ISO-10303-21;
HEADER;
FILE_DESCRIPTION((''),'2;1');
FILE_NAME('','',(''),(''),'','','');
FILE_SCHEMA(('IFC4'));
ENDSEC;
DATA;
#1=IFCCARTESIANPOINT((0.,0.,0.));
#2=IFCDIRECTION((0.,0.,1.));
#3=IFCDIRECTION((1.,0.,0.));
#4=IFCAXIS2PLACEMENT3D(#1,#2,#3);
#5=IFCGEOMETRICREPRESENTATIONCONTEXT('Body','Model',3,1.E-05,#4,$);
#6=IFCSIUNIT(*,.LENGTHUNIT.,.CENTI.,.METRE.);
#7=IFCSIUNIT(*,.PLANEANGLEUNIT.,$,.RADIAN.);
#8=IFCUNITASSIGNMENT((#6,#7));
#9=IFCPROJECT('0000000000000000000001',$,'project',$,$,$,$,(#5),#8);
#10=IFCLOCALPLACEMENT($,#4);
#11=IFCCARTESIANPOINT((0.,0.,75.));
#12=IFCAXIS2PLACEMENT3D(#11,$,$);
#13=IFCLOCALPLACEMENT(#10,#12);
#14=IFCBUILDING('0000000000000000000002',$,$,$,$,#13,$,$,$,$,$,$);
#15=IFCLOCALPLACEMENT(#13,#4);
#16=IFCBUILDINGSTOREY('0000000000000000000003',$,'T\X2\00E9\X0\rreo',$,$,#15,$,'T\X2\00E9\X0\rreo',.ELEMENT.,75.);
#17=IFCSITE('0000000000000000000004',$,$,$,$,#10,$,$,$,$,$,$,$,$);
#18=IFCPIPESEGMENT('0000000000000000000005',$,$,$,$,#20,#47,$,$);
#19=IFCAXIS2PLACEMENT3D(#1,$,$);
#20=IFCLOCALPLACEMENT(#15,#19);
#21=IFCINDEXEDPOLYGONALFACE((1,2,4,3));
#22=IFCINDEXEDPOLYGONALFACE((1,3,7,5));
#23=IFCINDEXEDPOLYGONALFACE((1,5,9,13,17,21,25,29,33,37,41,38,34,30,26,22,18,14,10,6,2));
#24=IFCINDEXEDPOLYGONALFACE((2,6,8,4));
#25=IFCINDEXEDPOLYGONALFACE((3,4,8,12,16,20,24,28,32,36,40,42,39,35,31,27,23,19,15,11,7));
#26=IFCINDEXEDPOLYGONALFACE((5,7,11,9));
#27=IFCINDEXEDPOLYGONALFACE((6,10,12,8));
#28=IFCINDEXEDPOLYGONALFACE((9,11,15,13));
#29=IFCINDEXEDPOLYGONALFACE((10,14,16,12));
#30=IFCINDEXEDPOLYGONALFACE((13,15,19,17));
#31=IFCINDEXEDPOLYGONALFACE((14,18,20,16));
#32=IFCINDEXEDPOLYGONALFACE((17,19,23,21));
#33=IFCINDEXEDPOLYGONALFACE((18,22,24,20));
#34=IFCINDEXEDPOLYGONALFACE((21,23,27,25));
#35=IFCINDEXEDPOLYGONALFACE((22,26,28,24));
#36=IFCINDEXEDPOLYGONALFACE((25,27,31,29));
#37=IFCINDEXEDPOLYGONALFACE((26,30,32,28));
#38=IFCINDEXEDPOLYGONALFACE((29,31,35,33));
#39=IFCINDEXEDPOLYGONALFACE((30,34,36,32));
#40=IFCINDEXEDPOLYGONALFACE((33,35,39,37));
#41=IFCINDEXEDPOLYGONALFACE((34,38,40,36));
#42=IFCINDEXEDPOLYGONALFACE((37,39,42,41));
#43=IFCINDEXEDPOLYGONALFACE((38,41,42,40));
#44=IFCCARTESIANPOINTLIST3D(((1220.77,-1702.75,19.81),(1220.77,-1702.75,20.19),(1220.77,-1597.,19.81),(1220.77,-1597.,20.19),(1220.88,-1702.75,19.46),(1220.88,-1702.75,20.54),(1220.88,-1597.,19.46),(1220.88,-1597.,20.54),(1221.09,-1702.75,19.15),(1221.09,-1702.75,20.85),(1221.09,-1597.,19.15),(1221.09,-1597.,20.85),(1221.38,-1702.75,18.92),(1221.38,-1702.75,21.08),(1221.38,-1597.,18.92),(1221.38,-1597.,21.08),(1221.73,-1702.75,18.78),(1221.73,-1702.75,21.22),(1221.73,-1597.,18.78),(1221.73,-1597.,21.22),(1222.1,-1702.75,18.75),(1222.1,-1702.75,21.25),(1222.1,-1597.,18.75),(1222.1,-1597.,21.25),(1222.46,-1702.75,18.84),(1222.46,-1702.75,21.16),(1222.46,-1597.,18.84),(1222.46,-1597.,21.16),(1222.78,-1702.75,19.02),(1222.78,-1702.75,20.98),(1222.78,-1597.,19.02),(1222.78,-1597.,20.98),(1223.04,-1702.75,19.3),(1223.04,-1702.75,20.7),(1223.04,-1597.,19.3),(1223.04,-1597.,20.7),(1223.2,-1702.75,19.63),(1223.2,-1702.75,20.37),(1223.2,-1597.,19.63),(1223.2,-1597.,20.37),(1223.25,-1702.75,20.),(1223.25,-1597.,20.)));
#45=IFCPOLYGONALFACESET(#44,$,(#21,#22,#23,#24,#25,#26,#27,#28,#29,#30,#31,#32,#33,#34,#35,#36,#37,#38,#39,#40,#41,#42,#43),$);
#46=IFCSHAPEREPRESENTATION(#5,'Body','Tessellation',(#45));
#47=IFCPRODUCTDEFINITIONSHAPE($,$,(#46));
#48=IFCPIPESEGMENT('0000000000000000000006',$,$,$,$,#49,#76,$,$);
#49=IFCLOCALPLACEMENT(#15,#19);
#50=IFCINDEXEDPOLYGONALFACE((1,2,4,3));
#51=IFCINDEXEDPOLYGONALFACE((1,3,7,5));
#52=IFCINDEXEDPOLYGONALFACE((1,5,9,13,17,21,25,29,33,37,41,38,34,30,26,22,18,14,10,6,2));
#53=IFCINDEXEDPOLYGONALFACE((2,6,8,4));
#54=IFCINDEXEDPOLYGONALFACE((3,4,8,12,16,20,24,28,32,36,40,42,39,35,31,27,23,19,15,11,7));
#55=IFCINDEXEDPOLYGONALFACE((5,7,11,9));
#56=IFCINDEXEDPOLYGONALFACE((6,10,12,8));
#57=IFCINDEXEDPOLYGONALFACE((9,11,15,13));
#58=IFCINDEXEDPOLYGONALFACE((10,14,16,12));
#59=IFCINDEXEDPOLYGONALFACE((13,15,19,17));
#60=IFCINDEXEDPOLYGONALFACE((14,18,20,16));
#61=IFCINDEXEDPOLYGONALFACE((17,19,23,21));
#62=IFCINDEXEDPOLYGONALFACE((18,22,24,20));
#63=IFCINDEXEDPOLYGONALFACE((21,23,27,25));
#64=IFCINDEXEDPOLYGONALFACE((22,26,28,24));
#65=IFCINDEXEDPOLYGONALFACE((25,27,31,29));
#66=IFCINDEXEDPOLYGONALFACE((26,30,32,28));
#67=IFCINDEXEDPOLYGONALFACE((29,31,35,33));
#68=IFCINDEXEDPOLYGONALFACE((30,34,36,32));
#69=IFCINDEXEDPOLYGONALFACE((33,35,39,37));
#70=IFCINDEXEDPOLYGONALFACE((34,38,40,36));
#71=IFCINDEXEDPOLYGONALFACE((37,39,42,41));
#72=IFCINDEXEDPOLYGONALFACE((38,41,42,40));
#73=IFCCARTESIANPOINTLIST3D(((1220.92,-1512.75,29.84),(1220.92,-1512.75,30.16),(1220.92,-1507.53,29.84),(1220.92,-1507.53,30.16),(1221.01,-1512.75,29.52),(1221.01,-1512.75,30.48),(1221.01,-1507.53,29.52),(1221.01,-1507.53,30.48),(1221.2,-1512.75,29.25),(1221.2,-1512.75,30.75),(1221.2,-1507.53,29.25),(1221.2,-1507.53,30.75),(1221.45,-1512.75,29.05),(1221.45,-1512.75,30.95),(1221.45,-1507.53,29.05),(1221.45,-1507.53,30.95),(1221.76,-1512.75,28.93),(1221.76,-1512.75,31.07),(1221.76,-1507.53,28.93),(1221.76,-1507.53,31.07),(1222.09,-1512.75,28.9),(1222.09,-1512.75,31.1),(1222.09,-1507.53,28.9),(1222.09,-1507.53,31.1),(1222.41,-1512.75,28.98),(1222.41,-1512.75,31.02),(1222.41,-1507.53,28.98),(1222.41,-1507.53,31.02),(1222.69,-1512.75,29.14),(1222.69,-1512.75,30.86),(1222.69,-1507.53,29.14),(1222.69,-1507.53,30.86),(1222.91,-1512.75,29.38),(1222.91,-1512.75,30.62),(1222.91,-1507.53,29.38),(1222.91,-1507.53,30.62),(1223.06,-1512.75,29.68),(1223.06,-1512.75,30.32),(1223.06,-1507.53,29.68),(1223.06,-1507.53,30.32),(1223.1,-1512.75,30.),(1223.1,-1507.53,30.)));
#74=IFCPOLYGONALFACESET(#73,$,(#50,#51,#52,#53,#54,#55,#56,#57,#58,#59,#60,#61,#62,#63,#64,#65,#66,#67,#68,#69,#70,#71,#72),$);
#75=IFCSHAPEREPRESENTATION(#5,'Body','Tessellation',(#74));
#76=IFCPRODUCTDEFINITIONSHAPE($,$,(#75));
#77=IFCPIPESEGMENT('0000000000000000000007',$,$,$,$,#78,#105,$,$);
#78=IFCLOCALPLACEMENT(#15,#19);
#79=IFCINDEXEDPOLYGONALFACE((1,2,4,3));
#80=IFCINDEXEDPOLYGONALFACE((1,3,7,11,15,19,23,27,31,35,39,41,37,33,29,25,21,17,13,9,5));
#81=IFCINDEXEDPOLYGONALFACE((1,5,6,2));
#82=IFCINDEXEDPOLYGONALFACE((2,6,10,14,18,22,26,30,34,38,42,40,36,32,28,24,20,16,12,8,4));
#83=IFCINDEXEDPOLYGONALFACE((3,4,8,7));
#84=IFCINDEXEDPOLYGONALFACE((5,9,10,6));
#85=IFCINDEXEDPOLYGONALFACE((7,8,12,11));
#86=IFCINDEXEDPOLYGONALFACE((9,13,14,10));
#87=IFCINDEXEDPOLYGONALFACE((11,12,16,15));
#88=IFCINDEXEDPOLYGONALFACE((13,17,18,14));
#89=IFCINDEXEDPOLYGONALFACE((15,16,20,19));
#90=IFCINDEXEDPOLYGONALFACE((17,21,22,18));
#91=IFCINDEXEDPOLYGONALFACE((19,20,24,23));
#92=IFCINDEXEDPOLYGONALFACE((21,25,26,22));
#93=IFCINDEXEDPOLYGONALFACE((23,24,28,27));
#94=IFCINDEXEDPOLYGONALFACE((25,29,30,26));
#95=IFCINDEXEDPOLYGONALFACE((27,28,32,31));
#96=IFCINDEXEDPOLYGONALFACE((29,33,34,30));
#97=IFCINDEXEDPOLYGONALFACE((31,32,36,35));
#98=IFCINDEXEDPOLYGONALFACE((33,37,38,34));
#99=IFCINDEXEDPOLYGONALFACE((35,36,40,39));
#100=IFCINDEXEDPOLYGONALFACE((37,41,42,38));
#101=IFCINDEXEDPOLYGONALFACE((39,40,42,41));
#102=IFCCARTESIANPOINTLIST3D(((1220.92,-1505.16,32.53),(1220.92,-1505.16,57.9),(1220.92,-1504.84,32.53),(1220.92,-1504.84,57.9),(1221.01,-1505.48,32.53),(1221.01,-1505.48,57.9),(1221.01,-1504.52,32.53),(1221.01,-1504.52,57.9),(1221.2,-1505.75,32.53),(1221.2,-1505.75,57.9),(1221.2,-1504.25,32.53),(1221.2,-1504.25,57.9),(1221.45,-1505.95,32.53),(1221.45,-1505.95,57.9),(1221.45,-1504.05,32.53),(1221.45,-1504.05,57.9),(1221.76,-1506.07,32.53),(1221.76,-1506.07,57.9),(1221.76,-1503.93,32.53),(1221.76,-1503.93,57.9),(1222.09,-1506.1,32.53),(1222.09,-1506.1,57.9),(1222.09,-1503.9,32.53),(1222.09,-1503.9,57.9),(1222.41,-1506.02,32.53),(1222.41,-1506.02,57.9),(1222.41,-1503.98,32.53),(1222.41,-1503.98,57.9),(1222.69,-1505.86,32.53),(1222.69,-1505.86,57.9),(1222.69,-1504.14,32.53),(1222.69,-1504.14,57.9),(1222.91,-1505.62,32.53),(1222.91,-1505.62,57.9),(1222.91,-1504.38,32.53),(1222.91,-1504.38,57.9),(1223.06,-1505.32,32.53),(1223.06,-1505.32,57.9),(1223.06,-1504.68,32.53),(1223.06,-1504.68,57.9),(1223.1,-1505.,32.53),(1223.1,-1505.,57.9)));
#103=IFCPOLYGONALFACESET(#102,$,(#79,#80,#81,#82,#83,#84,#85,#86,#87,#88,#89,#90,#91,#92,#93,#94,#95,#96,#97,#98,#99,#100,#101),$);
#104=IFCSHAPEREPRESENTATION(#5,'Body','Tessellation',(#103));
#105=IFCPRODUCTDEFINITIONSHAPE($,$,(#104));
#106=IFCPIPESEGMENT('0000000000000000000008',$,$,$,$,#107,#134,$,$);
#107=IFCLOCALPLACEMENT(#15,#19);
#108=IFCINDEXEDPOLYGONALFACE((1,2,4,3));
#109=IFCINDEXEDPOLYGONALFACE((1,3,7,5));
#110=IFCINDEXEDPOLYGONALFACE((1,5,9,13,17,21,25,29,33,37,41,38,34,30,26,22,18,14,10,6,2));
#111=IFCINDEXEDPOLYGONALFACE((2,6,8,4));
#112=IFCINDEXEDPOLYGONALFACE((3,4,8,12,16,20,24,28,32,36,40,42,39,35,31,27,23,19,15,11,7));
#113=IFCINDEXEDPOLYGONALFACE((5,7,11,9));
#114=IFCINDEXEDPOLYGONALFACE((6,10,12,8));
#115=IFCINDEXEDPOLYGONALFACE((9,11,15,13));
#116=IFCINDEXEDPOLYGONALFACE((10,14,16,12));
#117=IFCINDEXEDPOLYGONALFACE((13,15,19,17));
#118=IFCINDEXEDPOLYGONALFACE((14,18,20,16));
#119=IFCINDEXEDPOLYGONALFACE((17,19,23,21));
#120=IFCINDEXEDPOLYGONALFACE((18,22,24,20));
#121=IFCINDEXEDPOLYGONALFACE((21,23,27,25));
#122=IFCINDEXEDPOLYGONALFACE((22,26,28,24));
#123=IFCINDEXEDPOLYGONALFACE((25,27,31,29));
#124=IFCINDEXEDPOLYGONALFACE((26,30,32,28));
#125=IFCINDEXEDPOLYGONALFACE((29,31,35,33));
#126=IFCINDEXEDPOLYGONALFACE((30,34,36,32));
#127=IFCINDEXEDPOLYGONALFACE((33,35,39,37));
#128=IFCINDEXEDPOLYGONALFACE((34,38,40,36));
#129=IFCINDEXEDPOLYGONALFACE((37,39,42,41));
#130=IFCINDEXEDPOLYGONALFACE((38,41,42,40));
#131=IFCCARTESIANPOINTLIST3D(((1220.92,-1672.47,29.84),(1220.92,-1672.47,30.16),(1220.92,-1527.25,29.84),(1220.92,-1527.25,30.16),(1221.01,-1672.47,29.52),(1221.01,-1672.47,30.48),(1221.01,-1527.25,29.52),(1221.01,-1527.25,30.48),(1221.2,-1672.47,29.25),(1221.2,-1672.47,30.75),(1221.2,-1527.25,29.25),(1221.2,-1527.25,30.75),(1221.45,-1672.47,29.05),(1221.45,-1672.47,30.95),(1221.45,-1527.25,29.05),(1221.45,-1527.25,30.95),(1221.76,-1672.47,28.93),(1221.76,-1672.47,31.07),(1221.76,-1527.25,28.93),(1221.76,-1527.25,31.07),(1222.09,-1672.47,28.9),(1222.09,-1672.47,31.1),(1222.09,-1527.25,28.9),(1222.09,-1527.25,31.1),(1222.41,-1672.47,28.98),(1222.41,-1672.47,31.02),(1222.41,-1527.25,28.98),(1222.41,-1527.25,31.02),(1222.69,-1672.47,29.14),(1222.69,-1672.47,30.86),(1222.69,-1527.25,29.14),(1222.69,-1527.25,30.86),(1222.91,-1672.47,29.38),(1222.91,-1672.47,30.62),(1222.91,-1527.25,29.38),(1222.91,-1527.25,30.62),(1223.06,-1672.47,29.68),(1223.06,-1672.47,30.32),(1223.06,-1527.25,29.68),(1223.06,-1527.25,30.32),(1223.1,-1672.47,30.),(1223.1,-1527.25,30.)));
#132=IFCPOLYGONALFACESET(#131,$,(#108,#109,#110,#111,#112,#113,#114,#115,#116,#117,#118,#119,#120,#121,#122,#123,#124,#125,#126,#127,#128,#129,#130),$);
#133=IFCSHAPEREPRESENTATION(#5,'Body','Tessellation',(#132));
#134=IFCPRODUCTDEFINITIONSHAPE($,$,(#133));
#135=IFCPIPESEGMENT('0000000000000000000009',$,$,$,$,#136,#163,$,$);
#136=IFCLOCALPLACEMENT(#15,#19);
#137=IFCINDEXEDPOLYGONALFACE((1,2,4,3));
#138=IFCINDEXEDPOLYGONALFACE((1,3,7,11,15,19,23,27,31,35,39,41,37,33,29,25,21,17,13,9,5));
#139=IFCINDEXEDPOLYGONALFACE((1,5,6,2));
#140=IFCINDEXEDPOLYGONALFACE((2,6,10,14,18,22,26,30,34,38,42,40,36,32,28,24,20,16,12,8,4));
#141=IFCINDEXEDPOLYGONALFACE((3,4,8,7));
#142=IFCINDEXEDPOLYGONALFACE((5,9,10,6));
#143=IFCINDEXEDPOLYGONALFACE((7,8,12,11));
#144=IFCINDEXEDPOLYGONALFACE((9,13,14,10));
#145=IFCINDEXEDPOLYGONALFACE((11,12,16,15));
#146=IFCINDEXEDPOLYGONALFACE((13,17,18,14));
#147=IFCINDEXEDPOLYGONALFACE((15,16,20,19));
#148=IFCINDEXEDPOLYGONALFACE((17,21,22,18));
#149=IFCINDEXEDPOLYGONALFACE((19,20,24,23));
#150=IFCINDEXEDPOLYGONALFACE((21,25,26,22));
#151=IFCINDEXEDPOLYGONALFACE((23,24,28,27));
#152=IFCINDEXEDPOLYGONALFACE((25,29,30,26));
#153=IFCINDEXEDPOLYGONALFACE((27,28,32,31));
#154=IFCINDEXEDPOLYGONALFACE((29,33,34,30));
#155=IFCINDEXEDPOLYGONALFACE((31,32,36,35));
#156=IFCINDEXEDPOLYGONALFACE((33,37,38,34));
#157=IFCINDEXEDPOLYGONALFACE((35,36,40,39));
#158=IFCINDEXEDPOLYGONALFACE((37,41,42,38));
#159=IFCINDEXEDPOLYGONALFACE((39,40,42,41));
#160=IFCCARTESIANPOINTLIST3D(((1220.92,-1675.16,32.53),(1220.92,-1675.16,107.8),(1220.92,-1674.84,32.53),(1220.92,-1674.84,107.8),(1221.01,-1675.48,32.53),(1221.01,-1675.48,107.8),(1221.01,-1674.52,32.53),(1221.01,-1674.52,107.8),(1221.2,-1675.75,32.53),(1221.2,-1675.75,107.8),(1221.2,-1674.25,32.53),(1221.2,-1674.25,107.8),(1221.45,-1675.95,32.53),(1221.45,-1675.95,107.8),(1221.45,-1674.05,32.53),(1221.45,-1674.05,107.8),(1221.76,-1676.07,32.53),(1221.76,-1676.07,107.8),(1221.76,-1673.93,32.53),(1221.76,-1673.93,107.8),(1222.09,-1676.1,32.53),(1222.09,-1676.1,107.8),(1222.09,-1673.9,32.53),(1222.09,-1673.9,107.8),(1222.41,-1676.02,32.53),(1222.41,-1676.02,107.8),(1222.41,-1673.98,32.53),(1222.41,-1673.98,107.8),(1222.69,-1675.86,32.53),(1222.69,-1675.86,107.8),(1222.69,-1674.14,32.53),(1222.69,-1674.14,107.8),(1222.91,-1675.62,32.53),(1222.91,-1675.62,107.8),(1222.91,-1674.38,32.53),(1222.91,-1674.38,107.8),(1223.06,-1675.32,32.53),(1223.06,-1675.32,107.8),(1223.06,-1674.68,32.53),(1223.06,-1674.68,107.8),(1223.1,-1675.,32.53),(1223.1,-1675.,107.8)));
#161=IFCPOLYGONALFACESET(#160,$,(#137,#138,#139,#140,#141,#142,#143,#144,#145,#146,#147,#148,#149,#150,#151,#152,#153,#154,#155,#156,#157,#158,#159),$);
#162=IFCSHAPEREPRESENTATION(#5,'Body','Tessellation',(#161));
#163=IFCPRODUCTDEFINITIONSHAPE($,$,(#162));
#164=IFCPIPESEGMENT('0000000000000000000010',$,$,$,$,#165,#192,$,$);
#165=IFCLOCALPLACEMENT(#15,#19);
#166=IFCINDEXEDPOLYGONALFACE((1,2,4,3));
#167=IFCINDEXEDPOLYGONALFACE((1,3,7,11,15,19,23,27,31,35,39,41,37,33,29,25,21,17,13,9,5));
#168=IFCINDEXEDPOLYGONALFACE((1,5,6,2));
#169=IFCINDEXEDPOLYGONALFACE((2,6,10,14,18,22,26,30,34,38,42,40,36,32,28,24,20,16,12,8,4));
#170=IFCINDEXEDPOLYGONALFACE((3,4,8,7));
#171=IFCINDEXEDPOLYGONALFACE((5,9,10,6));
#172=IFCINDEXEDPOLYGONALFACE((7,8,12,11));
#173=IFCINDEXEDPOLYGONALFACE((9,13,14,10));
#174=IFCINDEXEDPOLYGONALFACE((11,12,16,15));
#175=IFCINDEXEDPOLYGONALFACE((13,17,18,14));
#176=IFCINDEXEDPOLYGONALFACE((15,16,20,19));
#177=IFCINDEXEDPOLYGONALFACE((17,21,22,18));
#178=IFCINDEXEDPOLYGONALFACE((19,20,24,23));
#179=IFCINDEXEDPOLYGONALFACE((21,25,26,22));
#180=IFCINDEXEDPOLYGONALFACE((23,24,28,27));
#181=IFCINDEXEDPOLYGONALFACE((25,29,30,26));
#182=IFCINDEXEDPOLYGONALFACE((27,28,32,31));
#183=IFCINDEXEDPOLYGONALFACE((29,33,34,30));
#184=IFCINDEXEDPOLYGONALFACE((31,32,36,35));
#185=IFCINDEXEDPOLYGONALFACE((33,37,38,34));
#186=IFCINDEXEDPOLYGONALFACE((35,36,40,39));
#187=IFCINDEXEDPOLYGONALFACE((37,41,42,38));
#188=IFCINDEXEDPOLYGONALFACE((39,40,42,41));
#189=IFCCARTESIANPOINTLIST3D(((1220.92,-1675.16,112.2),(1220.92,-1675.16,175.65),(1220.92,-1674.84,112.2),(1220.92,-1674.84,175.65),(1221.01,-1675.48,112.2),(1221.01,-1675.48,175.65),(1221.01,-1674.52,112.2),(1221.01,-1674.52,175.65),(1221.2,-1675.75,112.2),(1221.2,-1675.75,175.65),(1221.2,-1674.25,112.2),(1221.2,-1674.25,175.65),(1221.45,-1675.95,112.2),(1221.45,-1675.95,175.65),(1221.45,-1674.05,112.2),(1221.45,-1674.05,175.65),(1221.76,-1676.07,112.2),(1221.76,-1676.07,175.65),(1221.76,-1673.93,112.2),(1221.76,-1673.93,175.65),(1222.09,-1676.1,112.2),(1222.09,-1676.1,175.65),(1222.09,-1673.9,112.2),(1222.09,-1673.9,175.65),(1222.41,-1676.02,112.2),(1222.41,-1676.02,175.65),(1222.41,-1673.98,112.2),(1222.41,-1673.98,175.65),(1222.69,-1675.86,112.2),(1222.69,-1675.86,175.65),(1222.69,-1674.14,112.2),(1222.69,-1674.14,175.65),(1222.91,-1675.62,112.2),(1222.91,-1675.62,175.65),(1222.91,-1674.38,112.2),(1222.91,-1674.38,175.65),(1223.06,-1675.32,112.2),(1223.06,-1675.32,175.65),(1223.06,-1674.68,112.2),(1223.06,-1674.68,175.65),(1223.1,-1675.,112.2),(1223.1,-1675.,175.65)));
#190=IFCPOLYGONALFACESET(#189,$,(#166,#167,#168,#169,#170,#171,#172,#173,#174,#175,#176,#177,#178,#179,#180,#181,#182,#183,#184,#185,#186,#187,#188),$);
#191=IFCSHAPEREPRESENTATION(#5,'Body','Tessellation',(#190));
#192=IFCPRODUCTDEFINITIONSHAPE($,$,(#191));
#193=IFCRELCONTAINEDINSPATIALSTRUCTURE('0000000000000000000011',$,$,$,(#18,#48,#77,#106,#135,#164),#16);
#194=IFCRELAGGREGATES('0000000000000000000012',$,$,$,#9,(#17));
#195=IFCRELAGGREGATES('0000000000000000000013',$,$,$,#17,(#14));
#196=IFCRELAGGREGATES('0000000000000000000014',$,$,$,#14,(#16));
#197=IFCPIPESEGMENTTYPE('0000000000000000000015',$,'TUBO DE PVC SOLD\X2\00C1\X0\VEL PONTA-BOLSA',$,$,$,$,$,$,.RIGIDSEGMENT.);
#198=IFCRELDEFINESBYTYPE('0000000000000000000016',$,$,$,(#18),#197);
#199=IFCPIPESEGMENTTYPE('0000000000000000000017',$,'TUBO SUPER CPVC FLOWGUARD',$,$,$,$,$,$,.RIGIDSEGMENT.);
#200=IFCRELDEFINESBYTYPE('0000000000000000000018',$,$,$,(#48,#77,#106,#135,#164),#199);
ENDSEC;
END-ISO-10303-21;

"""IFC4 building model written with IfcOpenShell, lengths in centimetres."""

from ifc_helpers import new_model, si_unit, frame, origin_with_axes, origin_2d_with_axis, place, context, project, spatial, circle, extrude, type_object, element, save


model = new_model("IFC4")

# Units and contexts
model_context = context("Model", 3, precision=1e-05, world=origin_with_axes(), identifier="Body")
ifc_project = project(units=[si_unit("LENGTHUNIT", "METRE", prefix="CENTI"), si_unit("PLANEANGLEUNIT", "RADIAN")], contexts=[model_context])

# Site, building, storey
site_placement = place(None, origin_with_axes())
site = spatial("IfcSite", under=ifc_project, at=site_placement)
building_placement = place(site_placement, frame((0.0, 0.0, 75.0)))
building = spatial("IfcBuilding", under=site, at=building_placement)
storey_placement = place(building_placement, origin_with_axes())
storey = spatial("IfcBuildingStorey", under=building, at=storey_placement, Name="Térreo", LongName="Térreo", CompositionType="ELEMENT", Elevation=75.0)

# Pipe segments
pipe_segment_type_1 = type_object("IfcPipeSegmentType", Name="TUBO DE PVC SOLDÁVEL PONTA-BOLSA", PredefinedType="RIGIDSEGMENT")
pipe_segment_1_placement = place(storey_placement, frame((1222.0, -1649.87, 21.25), z_axis=(0.0, 0.0, 1.0), x_axis=(1.0, 0.0, 0.0)))
element("IfcPipeSegment", 1, at=pipe_segment_1_placement, inside=storey, type_object=pipe_segment_type_1, context=model_context, shape_type="SolidModel", body=[
    extrude(circle(Radius=1.25, at=origin_2d_with_axis()), frame((0.0, -52.88, -1.25), z_axis=(0.0, 1.0, 0.0), x_axis=(1.0, 0.0, 0.0)), (0.0, 0.0, 1.0), 105.75),
])
pipe_segment_type_2 = type_object("IfcPipeSegmentType", Name="TUBO SUPER CPVC FLOWGUARD", PredefinedType="RIGIDSEGMENT")
pipe_segment_2_placement = place(storey_placement, frame((1222.0, -1510.14, 31.1), z_axis=(0.0, 0.0, 1.0), x_axis=(1.0, 0.0, 0.0)))
element("IfcPipeSegment", 2, at=pipe_segment_2_placement, inside=storey, type_object=pipe_segment_type_2, context=model_context, shape_type="SolidModel", body=[
    extrude(circle(Radius=1.1, at=origin_2d_with_axis()), frame((0.0, -2.61, -1.1), z_axis=(0.0, 1.0, 0.0), x_axis=(1.0, 0.0, 0.0)), (0.0, 0.0, 1.0), 5.22),
])
pipe_segment_3_placement = place(storey_placement, frame((1222.0, -1505.0, 57.9), z_axis=(0.0, 0.0, 1.0), x_axis=(1.0, 0.0, 0.0)))
element("IfcPipeSegment", 3, at=pipe_segment_3_placement, inside=storey, type_object=pipe_segment_type_2, context=model_context, shape_type="SolidModel", body=[
    extrude(circle(Radius=1.1, at=origin_2d_with_axis()), frame((0.0, 0.0, -25.37), z_axis=(0.0, 0.0, 1.0), x_axis=(1.0, 0.0, 0.0)), (0.0, 0.0, 1.0), 25.37),
])
pipe_segment_4_placement = place(storey_placement, frame((1222.0, -1599.86, 31.1), z_axis=(0.0, 0.0, 1.0), x_axis=(1.0, 0.0, 0.0)))
element("IfcPipeSegment", 4, at=pipe_segment_4_placement, inside=storey, type_object=pipe_segment_type_2, context=model_context, shape_type="SolidModel", body=[
    extrude(circle(Radius=1.1, at=origin_2d_with_axis()), frame((0.0, -72.61, -1.1), z_axis=(0.0, 1.0, 0.0), x_axis=(1.0, 0.0, 0.0)), (0.0, 0.0, 1.0), 145.22),
])
pipe_segment_5_placement = place(storey_placement, frame((1222.0, -1675.0, 107.8), z_axis=(0.0, 0.0, 1.0), x_axis=(1.0, 0.0, 0.0)))
element("IfcPipeSegment", 5, at=pipe_segment_5_placement, inside=storey, type_object=pipe_segment_type_2, context=model_context, shape_type="SolidModel", body=[
    extrude(circle(Radius=1.1, at=origin_2d_with_axis()), frame((0.0, 0.0, 0.0), z_axis=(0.0, 0.0, -1.0), x_axis=(1.0, 0.0, 0.0)), (0.0, 0.0, 1.0), 75.27),
])
pipe_segment_6_placement = place(storey_placement, frame((1222.0, -1675.0, 175.65), z_axis=(0.0, 0.0, 1.0), x_axis=(1.0, 0.0, 0.0)))
element("IfcPipeSegment", 6, at=pipe_segment_6_placement, inside=storey, type_object=pipe_segment_type_2, context=model_context, shape_type="SolidModel", body=[
    extrude(circle(Radius=1.1, at=origin_2d_with_axis()), frame((0.0, 0.0, 0.0), z_axis=(0.0, 0.0, -1.0), x_axis=(1.0, 0.0, 0.0)), (0.0, 0.0, 1.0), 63.45),
])

save(model, "model.ifc")
